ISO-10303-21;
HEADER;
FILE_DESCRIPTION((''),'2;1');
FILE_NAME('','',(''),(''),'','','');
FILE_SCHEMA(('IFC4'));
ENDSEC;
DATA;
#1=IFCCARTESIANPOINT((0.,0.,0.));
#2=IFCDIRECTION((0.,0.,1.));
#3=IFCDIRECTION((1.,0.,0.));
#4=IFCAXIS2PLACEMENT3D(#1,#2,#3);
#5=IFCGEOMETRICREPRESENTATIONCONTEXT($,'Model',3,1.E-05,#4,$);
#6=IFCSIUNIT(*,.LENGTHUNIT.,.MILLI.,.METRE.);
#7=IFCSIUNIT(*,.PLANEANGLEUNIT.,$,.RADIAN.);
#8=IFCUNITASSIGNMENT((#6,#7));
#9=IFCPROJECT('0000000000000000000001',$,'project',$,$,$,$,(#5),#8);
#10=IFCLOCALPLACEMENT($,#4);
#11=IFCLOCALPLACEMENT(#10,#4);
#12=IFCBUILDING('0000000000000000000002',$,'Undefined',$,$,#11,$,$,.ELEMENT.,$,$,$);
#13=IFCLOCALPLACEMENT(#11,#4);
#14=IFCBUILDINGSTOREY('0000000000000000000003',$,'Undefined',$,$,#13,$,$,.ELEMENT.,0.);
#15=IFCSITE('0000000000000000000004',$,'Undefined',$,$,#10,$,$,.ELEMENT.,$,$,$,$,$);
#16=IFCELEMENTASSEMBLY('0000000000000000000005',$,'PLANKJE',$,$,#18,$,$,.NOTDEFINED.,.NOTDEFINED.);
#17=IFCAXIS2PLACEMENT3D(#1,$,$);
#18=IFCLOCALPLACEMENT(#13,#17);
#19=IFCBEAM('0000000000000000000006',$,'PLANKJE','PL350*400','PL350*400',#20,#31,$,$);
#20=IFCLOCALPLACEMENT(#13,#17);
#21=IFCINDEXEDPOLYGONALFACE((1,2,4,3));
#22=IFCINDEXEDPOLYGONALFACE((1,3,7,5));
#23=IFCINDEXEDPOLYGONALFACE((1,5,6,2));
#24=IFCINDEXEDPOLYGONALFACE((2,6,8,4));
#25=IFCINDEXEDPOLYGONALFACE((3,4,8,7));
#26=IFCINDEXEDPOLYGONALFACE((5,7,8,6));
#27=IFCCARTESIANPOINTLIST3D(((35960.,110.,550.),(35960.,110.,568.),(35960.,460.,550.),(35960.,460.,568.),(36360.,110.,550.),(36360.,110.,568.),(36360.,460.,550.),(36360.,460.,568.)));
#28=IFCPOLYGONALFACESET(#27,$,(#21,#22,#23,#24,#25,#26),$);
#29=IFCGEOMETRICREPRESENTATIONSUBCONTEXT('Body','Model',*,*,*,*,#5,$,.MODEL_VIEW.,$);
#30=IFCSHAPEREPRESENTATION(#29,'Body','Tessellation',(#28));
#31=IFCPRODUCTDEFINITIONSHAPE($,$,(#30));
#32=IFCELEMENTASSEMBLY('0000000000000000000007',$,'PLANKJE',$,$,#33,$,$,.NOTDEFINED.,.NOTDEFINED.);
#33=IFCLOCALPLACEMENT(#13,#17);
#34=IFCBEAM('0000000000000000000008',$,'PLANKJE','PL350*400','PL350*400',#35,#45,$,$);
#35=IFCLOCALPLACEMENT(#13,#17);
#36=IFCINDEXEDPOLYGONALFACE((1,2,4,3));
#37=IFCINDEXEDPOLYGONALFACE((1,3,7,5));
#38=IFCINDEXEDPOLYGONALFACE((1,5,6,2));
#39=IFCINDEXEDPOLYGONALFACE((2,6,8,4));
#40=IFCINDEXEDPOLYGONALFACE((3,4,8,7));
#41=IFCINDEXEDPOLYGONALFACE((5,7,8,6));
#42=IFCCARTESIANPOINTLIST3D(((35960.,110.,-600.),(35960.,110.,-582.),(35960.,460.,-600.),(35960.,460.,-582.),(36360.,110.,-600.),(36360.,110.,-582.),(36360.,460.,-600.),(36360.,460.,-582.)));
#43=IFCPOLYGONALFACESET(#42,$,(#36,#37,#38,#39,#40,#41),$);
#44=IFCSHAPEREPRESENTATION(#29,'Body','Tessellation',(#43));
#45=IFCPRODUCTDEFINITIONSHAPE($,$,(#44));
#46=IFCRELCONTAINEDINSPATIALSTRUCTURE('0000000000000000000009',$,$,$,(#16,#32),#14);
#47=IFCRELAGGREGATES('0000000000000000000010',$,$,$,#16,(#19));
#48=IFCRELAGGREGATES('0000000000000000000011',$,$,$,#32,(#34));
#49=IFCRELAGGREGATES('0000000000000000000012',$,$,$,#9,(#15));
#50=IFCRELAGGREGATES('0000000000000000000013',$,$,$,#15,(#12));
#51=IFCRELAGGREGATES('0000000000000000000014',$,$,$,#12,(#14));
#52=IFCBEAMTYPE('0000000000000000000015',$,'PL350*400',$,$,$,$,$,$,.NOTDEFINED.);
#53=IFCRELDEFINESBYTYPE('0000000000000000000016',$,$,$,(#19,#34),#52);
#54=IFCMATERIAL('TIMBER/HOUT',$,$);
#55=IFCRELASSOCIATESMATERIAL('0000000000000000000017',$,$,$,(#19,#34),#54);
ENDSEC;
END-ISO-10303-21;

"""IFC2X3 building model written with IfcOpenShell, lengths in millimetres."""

from ifc_helpers import new_model, si_unit, frame, frame_2d, origin_with_axes, place, context, subcontext, project, spatial, rectangle, extrude, material, type_object, element, aggregate, save


model = new_model("IFC2X3")

# Units and contexts
model_context = context("Model", 3, precision=1e-05, world=origin_with_axes())
body_context = subcontext(model_context, "Body", "Model", "MODEL_VIEW")
ifc_project = project(units=[si_unit("LENGTHUNIT", "METRE", prefix="MILLI"), si_unit("PLANEANGLEUNIT", "RADIAN")], contexts=[model_context])

# Site, building, storey
site_placement = place(None, origin_with_axes())
site = spatial("IfcSite", under=ifc_project, at=site_placement, Name="Undefined", CompositionType="ELEMENT")
building_placement = place(site_placement, origin_with_axes())
building = spatial("IfcBuilding", under=site, at=building_placement, Name="Undefined", CompositionType="ELEMENT")
storey_placement = place(building_placement, origin_with_axes())
storey = spatial("IfcBuildingStorey", under=building, at=storey_placement, Name="Undefined", CompositionType="ELEMENT", Elevation=0.0)

# Shared definitions
ifc_material_1 = material(Name="TIMBER/HOUT")

# Element assemblies, beams
assembly_1_placement = place(storey_placement, origin_with_axes())
assembly_1 = element("IfcElementAssembly", 1, at=assembly_1_placement, inside=storey, Name="PLANKJE", AssemblyPlace="NOTDEFINED", PredefinedType="NOTDEFINED")
beam_type_1 = type_object("IfcBeamType", Name="PL350*400", PredefinedType="NOTDEFINED")
beam_1_placement = place(assembly_1_placement, frame((36160.0, 285.0, 550.0), z_axis=(-1.0, 0.0, 0.0), x_axis=(0.0, 0.0, 1.0)))
beam_1 = element("IfcBeam", 2, at=beam_1_placement, type_object=beam_type_1, material=ifc_material_1, Name="PLANKJE", Description="PL350*400", ObjectType="PL350*400", context=body_context, shape_type="SweptSolid", body=[
    extrude(rectangle(XDim=350.0, YDim=400.0, at=frame_2d((0.0, 0.0), x_axis=(1.0, 0.0))), frame((18.0, 0.0, 0.0), z_axis=(-1.0, 0.0, 0.0), x_axis=(0.0, -1.0, 0.0)), (0.0, 0.0, 1.0), 18.0),
])
aggregate(assembly_1, [beam_1])
assembly_2_placement = place(storey_placement, origin_with_axes())
assembly_2 = element("IfcElementAssembly", 3, at=assembly_2_placement, inside=storey, Name="PLANKJE", AssemblyPlace="NOTDEFINED", PredefinedType="NOTDEFINED")
beam_2_placement = place(assembly_2_placement, frame((36160.0, 285.0, -600.0), z_axis=(-1.0, 0.0, 0.0), x_axis=(0.0, 0.0, 1.0)))
beam_2 = element("IfcBeam", 4, at=beam_2_placement, type_object=beam_type_1, material=ifc_material_1, Name="PLANKJE", Description="PL350*400", ObjectType="PL350*400", context=body_context, shape_type="SweptSolid", body=[
    extrude(rectangle(XDim=350.0, YDim=400.0, at=frame_2d((0.0, 0.0), x_axis=(1.0, 0.0))), frame((18.0, 0.0, 0.0), z_axis=(-1.0, 0.0, 0.0), x_axis=(0.0, -1.0, 0.0)), (0.0, 0.0, 1.0), 18.0),
])
aggregate(assembly_2, [beam_2])

save(model, "model.ifc")
